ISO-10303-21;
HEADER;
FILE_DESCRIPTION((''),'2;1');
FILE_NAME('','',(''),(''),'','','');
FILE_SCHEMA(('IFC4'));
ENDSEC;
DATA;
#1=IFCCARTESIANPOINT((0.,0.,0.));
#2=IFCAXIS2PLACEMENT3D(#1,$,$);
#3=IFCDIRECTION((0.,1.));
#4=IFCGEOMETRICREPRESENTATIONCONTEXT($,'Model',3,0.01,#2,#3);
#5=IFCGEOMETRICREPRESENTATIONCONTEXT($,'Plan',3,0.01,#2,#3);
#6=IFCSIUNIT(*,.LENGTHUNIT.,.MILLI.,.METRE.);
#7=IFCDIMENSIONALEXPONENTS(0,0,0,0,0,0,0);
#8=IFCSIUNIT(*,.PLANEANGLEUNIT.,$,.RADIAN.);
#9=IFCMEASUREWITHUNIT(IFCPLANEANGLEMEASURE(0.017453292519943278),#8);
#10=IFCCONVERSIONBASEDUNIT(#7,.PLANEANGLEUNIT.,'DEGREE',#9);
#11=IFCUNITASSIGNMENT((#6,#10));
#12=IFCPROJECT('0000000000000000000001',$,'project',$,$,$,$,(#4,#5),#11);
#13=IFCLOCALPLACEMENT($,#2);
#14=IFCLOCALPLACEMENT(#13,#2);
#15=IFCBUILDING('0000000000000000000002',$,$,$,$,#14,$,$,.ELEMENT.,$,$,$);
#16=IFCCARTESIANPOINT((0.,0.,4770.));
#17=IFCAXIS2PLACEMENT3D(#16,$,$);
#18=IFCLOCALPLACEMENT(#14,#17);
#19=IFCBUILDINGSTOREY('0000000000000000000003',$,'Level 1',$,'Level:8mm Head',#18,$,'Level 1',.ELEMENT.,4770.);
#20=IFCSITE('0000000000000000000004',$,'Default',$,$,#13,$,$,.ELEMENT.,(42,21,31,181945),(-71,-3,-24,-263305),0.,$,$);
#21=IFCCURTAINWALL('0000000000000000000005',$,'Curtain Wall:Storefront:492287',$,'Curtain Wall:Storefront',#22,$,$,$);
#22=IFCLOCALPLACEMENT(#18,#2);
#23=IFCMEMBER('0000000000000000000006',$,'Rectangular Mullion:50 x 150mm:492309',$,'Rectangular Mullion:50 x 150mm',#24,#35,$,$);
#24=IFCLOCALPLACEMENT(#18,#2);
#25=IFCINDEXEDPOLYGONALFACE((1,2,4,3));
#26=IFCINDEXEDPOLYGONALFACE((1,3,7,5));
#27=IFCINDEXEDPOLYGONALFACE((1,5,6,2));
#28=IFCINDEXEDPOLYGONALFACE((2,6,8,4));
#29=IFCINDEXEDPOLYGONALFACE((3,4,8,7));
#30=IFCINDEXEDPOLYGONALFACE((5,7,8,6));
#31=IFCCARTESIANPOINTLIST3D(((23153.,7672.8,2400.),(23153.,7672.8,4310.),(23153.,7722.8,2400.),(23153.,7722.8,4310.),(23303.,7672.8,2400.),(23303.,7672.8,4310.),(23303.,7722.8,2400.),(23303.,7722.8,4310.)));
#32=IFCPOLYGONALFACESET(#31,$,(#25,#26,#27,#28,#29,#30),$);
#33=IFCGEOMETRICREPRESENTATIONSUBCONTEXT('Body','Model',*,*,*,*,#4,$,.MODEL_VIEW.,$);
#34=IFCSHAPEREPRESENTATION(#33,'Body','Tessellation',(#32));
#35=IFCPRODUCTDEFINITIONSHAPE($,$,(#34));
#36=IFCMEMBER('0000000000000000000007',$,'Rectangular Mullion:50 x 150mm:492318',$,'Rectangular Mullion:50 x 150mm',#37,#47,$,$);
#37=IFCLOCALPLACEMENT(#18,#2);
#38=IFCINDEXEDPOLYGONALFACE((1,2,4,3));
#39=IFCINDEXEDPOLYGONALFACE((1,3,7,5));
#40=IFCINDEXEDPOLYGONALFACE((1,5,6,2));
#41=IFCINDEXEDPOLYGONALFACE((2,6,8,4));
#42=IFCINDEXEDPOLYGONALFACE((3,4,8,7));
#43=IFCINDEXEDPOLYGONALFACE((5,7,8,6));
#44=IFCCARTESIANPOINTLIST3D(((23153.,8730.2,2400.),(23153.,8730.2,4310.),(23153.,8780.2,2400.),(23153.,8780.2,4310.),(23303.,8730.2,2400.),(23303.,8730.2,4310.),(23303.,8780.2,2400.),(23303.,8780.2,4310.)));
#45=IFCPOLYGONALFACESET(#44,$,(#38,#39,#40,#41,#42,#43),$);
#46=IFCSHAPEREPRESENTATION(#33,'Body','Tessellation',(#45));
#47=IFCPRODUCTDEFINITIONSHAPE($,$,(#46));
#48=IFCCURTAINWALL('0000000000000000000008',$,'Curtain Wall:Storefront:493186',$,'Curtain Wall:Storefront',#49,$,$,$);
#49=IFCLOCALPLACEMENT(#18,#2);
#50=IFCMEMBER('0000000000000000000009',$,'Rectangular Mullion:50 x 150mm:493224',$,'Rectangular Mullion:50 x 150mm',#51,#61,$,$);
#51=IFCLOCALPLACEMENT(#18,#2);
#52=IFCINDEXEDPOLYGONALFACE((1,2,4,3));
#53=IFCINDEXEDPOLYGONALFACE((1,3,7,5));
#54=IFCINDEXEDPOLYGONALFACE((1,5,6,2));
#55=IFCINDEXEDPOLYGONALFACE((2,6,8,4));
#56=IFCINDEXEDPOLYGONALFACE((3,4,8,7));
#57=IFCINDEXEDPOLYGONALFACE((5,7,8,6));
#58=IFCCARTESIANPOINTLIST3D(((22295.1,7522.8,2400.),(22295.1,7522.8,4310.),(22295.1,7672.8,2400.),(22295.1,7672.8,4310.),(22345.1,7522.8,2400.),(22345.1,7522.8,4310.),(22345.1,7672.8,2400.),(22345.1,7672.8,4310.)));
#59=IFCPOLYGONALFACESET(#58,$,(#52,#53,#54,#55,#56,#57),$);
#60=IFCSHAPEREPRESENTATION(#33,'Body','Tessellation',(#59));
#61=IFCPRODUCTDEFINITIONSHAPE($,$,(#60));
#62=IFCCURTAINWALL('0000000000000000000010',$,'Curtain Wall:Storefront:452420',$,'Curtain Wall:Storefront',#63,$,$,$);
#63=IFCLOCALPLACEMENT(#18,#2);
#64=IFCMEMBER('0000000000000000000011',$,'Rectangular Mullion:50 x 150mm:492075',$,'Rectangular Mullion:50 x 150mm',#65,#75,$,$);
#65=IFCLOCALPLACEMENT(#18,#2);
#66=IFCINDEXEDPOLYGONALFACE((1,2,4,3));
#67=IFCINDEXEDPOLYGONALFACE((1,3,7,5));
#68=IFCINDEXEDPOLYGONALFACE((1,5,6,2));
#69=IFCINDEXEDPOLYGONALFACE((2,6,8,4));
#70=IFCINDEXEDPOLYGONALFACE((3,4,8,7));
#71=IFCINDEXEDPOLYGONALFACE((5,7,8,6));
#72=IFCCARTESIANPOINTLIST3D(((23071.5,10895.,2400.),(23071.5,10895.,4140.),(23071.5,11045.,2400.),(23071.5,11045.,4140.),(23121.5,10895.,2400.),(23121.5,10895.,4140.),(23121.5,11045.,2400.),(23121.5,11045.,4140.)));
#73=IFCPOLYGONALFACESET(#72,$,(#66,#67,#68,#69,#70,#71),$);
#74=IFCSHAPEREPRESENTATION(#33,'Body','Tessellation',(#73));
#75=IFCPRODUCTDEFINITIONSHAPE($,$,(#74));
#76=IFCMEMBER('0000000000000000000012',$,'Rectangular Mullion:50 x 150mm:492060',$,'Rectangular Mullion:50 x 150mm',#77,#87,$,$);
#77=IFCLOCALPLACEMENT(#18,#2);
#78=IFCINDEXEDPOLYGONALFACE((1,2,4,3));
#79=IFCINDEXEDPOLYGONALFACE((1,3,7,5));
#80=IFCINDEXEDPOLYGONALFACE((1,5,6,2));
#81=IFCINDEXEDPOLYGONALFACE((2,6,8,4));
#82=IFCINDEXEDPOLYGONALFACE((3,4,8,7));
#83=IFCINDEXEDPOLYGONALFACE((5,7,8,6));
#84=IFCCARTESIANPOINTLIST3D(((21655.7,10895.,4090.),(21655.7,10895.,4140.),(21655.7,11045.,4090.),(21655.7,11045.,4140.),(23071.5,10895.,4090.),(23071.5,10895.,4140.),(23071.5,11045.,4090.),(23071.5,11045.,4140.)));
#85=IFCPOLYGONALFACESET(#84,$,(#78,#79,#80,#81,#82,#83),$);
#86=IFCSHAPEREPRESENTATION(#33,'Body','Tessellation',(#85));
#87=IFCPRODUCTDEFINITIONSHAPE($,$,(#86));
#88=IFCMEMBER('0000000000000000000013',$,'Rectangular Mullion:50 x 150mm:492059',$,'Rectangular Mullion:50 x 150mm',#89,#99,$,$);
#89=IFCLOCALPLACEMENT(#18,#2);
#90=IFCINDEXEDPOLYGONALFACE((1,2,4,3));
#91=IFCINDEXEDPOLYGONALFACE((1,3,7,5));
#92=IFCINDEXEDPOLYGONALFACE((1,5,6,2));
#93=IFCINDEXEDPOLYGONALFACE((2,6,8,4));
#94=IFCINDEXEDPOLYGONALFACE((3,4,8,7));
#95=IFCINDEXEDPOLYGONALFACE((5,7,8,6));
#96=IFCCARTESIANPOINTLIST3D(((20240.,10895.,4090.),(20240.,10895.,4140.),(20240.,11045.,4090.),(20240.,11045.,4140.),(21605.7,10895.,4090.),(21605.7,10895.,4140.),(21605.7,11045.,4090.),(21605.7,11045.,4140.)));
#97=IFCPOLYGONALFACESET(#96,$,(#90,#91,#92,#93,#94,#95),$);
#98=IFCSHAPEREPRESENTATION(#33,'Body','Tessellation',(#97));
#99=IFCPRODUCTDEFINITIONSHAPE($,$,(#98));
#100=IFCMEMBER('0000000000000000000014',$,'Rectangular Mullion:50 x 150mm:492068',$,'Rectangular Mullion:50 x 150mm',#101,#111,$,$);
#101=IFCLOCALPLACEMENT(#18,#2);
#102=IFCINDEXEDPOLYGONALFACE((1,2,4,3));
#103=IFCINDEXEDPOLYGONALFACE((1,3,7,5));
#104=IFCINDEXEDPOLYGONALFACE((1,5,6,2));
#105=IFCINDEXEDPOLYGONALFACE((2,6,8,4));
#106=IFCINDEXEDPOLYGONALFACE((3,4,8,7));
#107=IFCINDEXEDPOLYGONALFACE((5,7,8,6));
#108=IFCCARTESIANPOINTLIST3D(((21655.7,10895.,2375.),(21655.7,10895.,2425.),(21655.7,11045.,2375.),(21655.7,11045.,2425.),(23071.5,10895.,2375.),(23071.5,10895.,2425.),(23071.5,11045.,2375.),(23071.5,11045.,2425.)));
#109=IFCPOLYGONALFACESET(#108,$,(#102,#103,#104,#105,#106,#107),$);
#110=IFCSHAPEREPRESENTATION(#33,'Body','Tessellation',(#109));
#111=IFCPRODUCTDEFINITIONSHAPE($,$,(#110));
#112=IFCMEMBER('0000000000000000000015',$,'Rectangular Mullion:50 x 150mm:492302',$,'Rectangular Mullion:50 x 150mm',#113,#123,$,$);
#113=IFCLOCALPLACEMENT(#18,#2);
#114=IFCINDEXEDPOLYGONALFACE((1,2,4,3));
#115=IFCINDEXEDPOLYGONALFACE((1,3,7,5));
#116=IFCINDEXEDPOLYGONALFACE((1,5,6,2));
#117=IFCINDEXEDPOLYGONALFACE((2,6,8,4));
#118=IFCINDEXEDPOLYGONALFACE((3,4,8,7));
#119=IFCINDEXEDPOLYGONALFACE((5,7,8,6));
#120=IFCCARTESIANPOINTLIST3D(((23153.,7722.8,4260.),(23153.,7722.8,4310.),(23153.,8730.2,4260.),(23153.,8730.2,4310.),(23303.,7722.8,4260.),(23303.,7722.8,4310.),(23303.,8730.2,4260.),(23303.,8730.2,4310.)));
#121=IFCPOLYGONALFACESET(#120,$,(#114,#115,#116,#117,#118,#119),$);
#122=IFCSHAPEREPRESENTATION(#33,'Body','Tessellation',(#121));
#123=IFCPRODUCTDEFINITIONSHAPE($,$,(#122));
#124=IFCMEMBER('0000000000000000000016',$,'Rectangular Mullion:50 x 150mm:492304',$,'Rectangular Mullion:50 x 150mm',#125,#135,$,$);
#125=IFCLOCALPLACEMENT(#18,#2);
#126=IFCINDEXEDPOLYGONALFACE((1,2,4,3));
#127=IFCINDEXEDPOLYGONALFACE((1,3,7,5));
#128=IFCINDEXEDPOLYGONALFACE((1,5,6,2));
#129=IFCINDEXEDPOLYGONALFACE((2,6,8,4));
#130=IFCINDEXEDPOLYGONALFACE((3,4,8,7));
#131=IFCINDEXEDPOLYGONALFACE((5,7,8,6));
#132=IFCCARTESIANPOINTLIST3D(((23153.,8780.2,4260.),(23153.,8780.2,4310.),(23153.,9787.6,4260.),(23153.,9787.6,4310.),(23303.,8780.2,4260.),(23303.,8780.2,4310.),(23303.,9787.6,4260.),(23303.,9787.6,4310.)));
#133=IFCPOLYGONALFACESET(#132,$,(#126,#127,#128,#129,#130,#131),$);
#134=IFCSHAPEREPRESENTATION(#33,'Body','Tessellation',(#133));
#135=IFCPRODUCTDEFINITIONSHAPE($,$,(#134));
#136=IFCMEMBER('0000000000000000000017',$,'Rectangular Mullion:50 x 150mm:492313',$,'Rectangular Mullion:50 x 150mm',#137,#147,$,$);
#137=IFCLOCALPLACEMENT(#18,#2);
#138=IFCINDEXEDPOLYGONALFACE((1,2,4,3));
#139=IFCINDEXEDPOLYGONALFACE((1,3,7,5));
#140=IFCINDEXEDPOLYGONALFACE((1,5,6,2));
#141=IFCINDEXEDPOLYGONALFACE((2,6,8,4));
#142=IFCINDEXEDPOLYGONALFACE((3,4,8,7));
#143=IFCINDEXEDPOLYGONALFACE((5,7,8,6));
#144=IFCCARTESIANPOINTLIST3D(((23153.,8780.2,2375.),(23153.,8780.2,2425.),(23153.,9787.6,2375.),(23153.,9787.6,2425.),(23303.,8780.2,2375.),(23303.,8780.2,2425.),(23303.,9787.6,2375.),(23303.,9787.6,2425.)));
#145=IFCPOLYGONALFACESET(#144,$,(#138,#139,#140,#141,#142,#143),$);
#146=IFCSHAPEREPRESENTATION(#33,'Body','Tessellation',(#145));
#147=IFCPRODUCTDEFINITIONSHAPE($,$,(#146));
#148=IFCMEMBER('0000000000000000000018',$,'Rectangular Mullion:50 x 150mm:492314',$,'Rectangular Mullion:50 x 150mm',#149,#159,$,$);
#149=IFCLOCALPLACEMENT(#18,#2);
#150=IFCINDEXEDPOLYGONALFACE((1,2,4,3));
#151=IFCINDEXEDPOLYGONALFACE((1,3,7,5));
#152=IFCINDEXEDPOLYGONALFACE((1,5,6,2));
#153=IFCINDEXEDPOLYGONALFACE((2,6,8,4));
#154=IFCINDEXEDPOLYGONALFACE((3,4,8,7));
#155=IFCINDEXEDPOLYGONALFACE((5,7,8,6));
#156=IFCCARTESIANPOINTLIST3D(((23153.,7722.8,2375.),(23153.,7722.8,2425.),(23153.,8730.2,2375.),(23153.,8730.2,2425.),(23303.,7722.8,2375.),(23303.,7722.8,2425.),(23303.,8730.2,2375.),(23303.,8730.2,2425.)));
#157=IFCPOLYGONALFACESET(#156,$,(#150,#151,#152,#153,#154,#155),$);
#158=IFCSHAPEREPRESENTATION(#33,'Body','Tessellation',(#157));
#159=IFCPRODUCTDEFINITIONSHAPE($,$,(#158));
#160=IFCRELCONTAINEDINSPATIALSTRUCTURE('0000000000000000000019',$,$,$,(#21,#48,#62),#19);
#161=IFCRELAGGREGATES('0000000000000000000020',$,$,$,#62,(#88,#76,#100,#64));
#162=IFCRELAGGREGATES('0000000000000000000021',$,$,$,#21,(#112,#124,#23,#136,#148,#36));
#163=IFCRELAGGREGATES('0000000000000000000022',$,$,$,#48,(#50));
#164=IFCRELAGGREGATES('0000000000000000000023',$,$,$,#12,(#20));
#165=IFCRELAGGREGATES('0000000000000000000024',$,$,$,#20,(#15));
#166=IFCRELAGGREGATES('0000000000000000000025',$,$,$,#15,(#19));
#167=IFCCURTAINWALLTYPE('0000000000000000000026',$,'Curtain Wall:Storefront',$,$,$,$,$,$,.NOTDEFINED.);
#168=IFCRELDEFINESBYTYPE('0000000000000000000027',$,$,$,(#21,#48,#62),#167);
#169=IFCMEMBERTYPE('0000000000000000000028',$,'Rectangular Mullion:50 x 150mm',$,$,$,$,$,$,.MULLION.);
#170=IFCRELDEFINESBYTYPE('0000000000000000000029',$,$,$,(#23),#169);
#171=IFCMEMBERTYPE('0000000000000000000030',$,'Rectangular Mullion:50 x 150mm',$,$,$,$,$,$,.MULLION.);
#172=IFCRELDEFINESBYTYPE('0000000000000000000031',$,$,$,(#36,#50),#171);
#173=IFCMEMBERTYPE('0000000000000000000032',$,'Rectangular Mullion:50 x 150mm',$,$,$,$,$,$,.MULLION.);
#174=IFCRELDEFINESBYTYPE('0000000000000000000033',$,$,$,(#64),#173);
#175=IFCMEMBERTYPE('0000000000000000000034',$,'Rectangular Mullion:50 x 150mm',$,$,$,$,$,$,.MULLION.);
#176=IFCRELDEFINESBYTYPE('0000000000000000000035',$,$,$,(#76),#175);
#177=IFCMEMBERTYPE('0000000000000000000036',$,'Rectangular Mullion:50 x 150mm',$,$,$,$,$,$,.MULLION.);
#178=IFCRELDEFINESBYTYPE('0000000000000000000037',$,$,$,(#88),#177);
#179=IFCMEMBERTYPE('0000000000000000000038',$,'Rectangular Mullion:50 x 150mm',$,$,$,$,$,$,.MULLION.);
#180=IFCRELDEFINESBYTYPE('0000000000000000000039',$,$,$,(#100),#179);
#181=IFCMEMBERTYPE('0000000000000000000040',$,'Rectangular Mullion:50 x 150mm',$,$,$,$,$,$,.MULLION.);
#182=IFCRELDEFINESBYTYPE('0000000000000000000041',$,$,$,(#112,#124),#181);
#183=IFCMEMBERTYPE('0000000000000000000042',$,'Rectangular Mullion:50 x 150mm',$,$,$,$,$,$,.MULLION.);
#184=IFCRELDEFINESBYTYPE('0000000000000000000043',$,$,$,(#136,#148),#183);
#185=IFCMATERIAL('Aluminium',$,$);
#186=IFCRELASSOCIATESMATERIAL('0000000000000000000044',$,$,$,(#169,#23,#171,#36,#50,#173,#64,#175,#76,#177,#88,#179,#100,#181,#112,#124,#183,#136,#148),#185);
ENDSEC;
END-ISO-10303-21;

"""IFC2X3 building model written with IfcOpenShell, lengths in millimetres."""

from ifc_helpers import new_model, entity, si_unit, converted_unit, direction, frame, origin, origin_2d_with_axis, place, context, subcontext, project, spatial, rectangle, extrude, source, transform, mapped, material, type_object, type_shapes, element, aggregate, save


model = new_model("IFC2X3")

# Units and contexts
model_context = context("Model", 3, precision=0.01, world=origin(), true_north=direction((0.0, 1.0)))
plan_context = context("Plan", 3, precision=0.01, world=origin(), true_north=direction((0.0, 1.0)))
body_context = subcontext(model_context, "Body", "Model", "MODEL_VIEW")
ifc_project = project(units=[si_unit("LENGTHUNIT", "METRE", prefix="MILLI"), converted_unit("PLANEANGLEUNIT", "DEGREE", entity("IfcPlaneAngleMeasure", 0.017453292519943278), si_unit("PLANEANGLEUNIT", "RADIAN"), dimensions=[0, 0, 0, 0, 0, 0, 0])], contexts=[model_context, plan_context])

# Site, building, storey
site_placement = place(None, origin())
site = spatial("IfcSite", under=ifc_project, at=site_placement, Name="Default", CompositionType="ELEMENT", RefLatitude=(42, 21, 31, 181945), RefLongitude=(-71, -3, -24, -263305), RefElevation=0.0)
building_placement = place(site_placement, origin())
building = spatial("IfcBuilding", under=site, at=building_placement, CompositionType="ELEMENT")
storey_placement = place(building_placement, frame((0.0, 0.0, 4770.0)))
storey = spatial("IfcBuildingStorey", under=building, at=storey_placement, Name="Level 1", ObjectType="Level:8mm Head", LongName="Level 1", CompositionType="ELEMENT", Elevation=4770.0)

# Curtain wall, members
curtain_wall_type = type_object("IfcCurtainWallType", Name="Curtain Wall:Storefront", PredefinedType="NOTDEFINED")
curtain_wall_1_placement = place(storey_placement, frame((0.0, 0.0, -4770.0)))
curtain_wall_1 = element("IfcCurtainWall", 1, at=curtain_wall_1_placement, inside=storey, type_object=curtain_wall_type, Name="Curtain Wall:Storefront:492287", ObjectType="Curtain Wall:Storefront")
ifc_material_1 = material(Name="Aluminium")
member_type_1 = type_object("IfcMemberType", Name="Rectangular Mullion:50 x 150mm", PredefinedType="MULLION", material=ifc_material_1)
shared_shape_1 = source(origin(), body_context, "Body", "SweptSolid", [
    extrude(rectangle(XDim=50.0, YDim=150.0, at=origin_2d_with_axis()), frame((-25.0, 0.0, -1910.0), z_axis=(0.0, 0.0, 1.0), x_axis=(-1.0, 0.0, 0.0)), (0.0, 0.0, 1.0), 1910.0),
])
type_shapes(member_type_1, [shared_shape_1])
member_1_placement = place(curtain_wall_1_placement, frame((23228.0, 7672.8, 7170.0), z_axis=(0.0, 0.0, -1.0), x_axis=(0.0, -1.0, 0.0)))
member_1 = element("IfcMember", 2, at=member_1_placement, type_object=member_type_1, material=ifc_material_1, Name="Rectangular Mullion:50 x 150mm:492309", ObjectType="Rectangular Mullion:50 x 150mm", context=body_context, shape_type="MappedRepresentation", body=[
    mapped(shared_shape_1, transform((0.0, 0.0, 0.0), scale=1.0)),
])
member_type_2 = type_object("IfcMemberType", Name="Rectangular Mullion:50 x 150mm", PredefinedType="MULLION", material=ifc_material_1)
shared_shape_2 = source(origin(), body_context, "Body", "SweptSolid", [
    extrude(rectangle(XDim=50.0, YDim=150.0, at=origin_2d_with_axis()), frame((0.0, 0.0, -1910.0), z_axis=(0.0, 0.0, 1.0), x_axis=(-1.0, 0.0, 0.0)), (0.0, 0.0, 1.0), 1910.0),
])
type_shapes(member_type_2, [shared_shape_2])
member_2_placement = place(curtain_wall_1_placement, frame((23228.0, 8755.2, 7170.0), z_axis=(0.0, 0.0, -1.0), x_axis=(0.0, -1.0, 0.0)))
member_2 = element("IfcMember", 3, at=member_2_placement, type_object=member_type_2, material=ifc_material_1, Name="Rectangular Mullion:50 x 150mm:492318", ObjectType="Rectangular Mullion:50 x 150mm", context=body_context, shape_type="MappedRepresentation", body=[
    mapped(shared_shape_2, transform((0.0, 0.0, 0.0), scale=1.0)),
])

# Curtain wall, member
curtain_wall_2_placement = place(storey_placement, frame((0.0, 0.0, -4770.0)))
curtain_wall_2 = element("IfcCurtainWall", 4, at=curtain_wall_2_placement, inside=storey, type_object=curtain_wall_type, Name="Curtain Wall:Storefront:493186", ObjectType="Curtain Wall:Storefront")
member_3_placement = place(curtain_wall_2_placement, frame((22320.1, 7597.8, 7170.0), z_axis=(0.0, 0.0, -1.0), x_axis=(-1.0, 0.0, 0.0)))
member_3 = element("IfcMember", 5, at=member_3_placement, type_object=member_type_2, material=ifc_material_1, Name="Rectangular Mullion:50 x 150mm:493224", ObjectType="Rectangular Mullion:50 x 150mm", context=body_context, shape_type="MappedRepresentation", body=[
    mapped(shared_shape_2, transform((0.0, 0.0, 0.0), scale=1.0)),
])

# Curtain wall, members
curtain_wall_3_placement = place(storey_placement, frame((0.0, 0.0, -4770.0)))
curtain_wall_3 = element("IfcCurtainWall", 6, at=curtain_wall_3_placement, inside=storey, type_object=curtain_wall_type, Name="Curtain Wall:Storefront:452420", ObjectType="Curtain Wall:Storefront")
member_type_3 = type_object("IfcMemberType", Name="Rectangular Mullion:50 x 150mm", PredefinedType="MULLION", material=ifc_material_1)
shared_shape_3 = source(origin(), body_context, "Body", "SweptSolid", [
    extrude(rectangle(XDim=50.0, YDim=150.0, at=origin_2d_with_axis()), frame((0.0, 0.0, -1740.0), z_axis=(0.0, 0.0, 1.0), x_axis=(-1.0, 0.0, 0.0)), (0.0, 0.0, 1.0), 1740.0),
])
type_shapes(member_type_3, [shared_shape_3])
member_4_placement = place(curtain_wall_3_placement, frame((23096.5, 10970.0, 7170.0), z_axis=(0.0, 0.0, -1.0), x_axis=(1.0, 0.0, 0.0)))
member_4 = element("IfcMember", 7, at=member_4_placement, type_object=member_type_3, material=ifc_material_1, Name="Rectangular Mullion:50 x 150mm:492075", ObjectType="Rectangular Mullion:50 x 150mm", context=body_context, shape_type="MappedRepresentation", body=[
    mapped(shared_shape_3, transform((0.0, 0.0, 0.0), scale=1.0)),
])
member_type_4 = type_object("IfcMemberType", Name="Rectangular Mullion:50 x 150mm", PredefinedType="MULLION", material=ifc_material_1)
shared_shape_4 = source(origin(), body_context, "Body", "SweptSolid", [
    extrude(rectangle(XDim=50.0, YDim=150.0, at=origin_2d_with_axis()), frame((-25.0, 0.0, -1415.7), z_axis=(0.0, 0.0, 1.0), x_axis=(-1.0, 0.0, 0.0)), (0.0, 0.0, 1.0), 1415.7),
])
type_shapes(member_type_4, [shared_shape_4])
member_5_placement = place(curtain_wall_3_placement, frame((23071.5, 10970.0, 8910.0), z_axis=(1.0, 0.0, 0.0), x_axis=(0.0, 0.0, 1.0)))
member_5 = element("IfcMember", 8, at=member_5_placement, type_object=member_type_4, material=ifc_material_1, Name="Rectangular Mullion:50 x 150mm:492060", ObjectType="Rectangular Mullion:50 x 150mm", context=body_context, shape_type="MappedRepresentation", body=[
    mapped(shared_shape_4, transform((0.0, 0.0, 0.0), scale=1.0)),
])
member_type_5 = type_object("IfcMemberType", Name="Rectangular Mullion:50 x 150mm", PredefinedType="MULLION", material=ifc_material_1)
shared_shape_5 = source(origin(), body_context, "Body", "SweptSolid", [
    extrude(rectangle(XDim=50.0, YDim=150.0, at=origin_2d_with_axis()), frame((-25.0, 0.0, -1365.7), z_axis=(0.0, 0.0, 1.0), x_axis=(-1.0, 0.0, 0.0)), (0.0, 0.0, 1.0), 1365.7),
])
type_shapes(member_type_5, [shared_shape_5])
member_6_placement = place(curtain_wall_3_placement, frame((21605.7, 10970.0, 8910.0), z_axis=(1.0, 0.0, 0.0), x_axis=(0.0, 0.0, 1.0)))
member_6 = element("IfcMember", 9, at=member_6_placement, type_object=member_type_5, material=ifc_material_1, Name="Rectangular Mullion:50 x 150mm:492059", ObjectType="Rectangular Mullion:50 x 150mm", context=body_context, shape_type="MappedRepresentation", body=[
    mapped(shared_shape_5, transform((0.0, 0.0, 0.0), scale=1.0)),
])
member_type_6 = type_object("IfcMemberType", Name="Rectangular Mullion:50 x 150mm", PredefinedType="MULLION", material=ifc_material_1)
shared_shape_6 = source(origin(), body_context, "Body", "SweptSolid", [
    extrude(rectangle(XDim=50.0, YDim=150.0, at=origin_2d_with_axis()), frame((0.0, 0.0, -1415.7), z_axis=(0.0, 0.0, 1.0), x_axis=(-1.0, 0.0, 0.0)), (0.0, 0.0, 1.0), 1415.7),
])
type_shapes(member_type_6, [shared_shape_6])
member_7_placement = place(curtain_wall_3_placement, frame((23071.5, 10970.0, 7170.0), z_axis=(1.0, 0.0, 0.0), x_axis=(0.0, 0.0, 1.0)))
member_7 = element("IfcMember", 10, at=member_7_placement, type_object=member_type_6, material=ifc_material_1, Name="Rectangular Mullion:50 x 150mm:492068", ObjectType="Rectangular Mullion:50 x 150mm", context=body_context, shape_type="MappedRepresentation", body=[
    mapped(shared_shape_6, transform((0.0, 0.0, 0.0), scale=1.0)),
])

# Members
member_type_7 = type_object("IfcMemberType", Name="Rectangular Mullion:50 x 150mm", PredefinedType="MULLION", material=ifc_material_1)
shared_shape_7 = source(origin(), body_context, "Body", "SweptSolid", [
    extrude(rectangle(XDim=50.0, YDim=150.0, at=origin_2d_with_axis()), frame((-25.0, 0.0, -1007.4), z_axis=(0.0, 0.0, 1.0), x_axis=(-1.0, 0.0, 0.0)), (0.0, 0.0, 1.0), 1007.4),
])
type_shapes(member_type_7, [shared_shape_7])
member_8_placement = place(curtain_wall_1_placement, frame((23228.0, 7722.8, 9080.0), z_axis=(0.0, -1.0, 0.0), x_axis=(0.0, 0.0, 1.0)))
member_8 = element("IfcMember", 11, at=member_8_placement, type_object=member_type_7, material=ifc_material_1, Name="Rectangular Mullion:50 x 150mm:492302", ObjectType="Rectangular Mullion:50 x 150mm", context=body_context, shape_type="MappedRepresentation", body=[
    mapped(shared_shape_7, transform((0.0, 0.0, 0.0), scale=1.0)),
])
member_9_placement = place(curtain_wall_1_placement, frame((23228.0, 8780.2, 9080.0), z_axis=(0.0, -1.0, 0.0), x_axis=(0.0, 0.0, 1.0)))
member_9 = element("IfcMember", 12, at=member_9_placement, type_object=member_type_7, material=ifc_material_1, Name="Rectangular Mullion:50 x 150mm:492304", ObjectType="Rectangular Mullion:50 x 150mm", context=body_context, shape_type="MappedRepresentation", body=[
    mapped(shared_shape_7, transform((0.0, 0.0, 0.0), scale=1.0)),
])
member_type_8 = type_object("IfcMemberType", Name="Rectangular Mullion:50 x 150mm", PredefinedType="MULLION", material=ifc_material_1)
shared_shape_8 = source(origin(), body_context, "Body", "SweptSolid", [
    extrude(rectangle(XDim=50.0, YDim=150.0, at=origin_2d_with_axis()), frame((0.0, 0.0, -1007.4), z_axis=(0.0, 0.0, 1.0), x_axis=(-1.0, 0.0, 0.0)), (0.0, 0.0, 1.0), 1007.4),
])
type_shapes(member_type_8, [shared_shape_8])
member_10_placement = place(curtain_wall_1_placement, frame((23228.0, 8780.2, 7170.0), z_axis=(0.0, -1.0, 0.0), x_axis=(0.0, 0.0, 1.0)))
member_10 = element("IfcMember", 13, at=member_10_placement, type_object=member_type_8, material=ifc_material_1, Name="Rectangular Mullion:50 x 150mm:492313", ObjectType="Rectangular Mullion:50 x 150mm", context=body_context, shape_type="MappedRepresentation", body=[
    mapped(shared_shape_8, transform((0.0, 0.0, 0.0), scale=1.0)),
])
member_11_placement = place(curtain_wall_1_placement, frame((23228.0, 7722.8, 7170.0), z_axis=(0.0, -1.0, 0.0), x_axis=(0.0, 0.0, 1.0)))
member_11 = element("IfcMember", 14, at=member_11_placement, type_object=member_type_8, material=ifc_material_1, Name="Rectangular Mullion:50 x 150mm:492314", ObjectType="Rectangular Mullion:50 x 150mm", context=body_context, shape_type="MappedRepresentation", body=[
    mapped(shared_shape_8, transform((0.0, 0.0, 0.0), scale=1.0)),
])

aggregate(curtain_wall_3, [member_6, member_5, member_7, member_4])
aggregate(curtain_wall_1, [member_8, member_9, member_1, member_10, member_11, member_2])
aggregate(curtain_wall_2, [member_3])

save(model, "model.ifc")
